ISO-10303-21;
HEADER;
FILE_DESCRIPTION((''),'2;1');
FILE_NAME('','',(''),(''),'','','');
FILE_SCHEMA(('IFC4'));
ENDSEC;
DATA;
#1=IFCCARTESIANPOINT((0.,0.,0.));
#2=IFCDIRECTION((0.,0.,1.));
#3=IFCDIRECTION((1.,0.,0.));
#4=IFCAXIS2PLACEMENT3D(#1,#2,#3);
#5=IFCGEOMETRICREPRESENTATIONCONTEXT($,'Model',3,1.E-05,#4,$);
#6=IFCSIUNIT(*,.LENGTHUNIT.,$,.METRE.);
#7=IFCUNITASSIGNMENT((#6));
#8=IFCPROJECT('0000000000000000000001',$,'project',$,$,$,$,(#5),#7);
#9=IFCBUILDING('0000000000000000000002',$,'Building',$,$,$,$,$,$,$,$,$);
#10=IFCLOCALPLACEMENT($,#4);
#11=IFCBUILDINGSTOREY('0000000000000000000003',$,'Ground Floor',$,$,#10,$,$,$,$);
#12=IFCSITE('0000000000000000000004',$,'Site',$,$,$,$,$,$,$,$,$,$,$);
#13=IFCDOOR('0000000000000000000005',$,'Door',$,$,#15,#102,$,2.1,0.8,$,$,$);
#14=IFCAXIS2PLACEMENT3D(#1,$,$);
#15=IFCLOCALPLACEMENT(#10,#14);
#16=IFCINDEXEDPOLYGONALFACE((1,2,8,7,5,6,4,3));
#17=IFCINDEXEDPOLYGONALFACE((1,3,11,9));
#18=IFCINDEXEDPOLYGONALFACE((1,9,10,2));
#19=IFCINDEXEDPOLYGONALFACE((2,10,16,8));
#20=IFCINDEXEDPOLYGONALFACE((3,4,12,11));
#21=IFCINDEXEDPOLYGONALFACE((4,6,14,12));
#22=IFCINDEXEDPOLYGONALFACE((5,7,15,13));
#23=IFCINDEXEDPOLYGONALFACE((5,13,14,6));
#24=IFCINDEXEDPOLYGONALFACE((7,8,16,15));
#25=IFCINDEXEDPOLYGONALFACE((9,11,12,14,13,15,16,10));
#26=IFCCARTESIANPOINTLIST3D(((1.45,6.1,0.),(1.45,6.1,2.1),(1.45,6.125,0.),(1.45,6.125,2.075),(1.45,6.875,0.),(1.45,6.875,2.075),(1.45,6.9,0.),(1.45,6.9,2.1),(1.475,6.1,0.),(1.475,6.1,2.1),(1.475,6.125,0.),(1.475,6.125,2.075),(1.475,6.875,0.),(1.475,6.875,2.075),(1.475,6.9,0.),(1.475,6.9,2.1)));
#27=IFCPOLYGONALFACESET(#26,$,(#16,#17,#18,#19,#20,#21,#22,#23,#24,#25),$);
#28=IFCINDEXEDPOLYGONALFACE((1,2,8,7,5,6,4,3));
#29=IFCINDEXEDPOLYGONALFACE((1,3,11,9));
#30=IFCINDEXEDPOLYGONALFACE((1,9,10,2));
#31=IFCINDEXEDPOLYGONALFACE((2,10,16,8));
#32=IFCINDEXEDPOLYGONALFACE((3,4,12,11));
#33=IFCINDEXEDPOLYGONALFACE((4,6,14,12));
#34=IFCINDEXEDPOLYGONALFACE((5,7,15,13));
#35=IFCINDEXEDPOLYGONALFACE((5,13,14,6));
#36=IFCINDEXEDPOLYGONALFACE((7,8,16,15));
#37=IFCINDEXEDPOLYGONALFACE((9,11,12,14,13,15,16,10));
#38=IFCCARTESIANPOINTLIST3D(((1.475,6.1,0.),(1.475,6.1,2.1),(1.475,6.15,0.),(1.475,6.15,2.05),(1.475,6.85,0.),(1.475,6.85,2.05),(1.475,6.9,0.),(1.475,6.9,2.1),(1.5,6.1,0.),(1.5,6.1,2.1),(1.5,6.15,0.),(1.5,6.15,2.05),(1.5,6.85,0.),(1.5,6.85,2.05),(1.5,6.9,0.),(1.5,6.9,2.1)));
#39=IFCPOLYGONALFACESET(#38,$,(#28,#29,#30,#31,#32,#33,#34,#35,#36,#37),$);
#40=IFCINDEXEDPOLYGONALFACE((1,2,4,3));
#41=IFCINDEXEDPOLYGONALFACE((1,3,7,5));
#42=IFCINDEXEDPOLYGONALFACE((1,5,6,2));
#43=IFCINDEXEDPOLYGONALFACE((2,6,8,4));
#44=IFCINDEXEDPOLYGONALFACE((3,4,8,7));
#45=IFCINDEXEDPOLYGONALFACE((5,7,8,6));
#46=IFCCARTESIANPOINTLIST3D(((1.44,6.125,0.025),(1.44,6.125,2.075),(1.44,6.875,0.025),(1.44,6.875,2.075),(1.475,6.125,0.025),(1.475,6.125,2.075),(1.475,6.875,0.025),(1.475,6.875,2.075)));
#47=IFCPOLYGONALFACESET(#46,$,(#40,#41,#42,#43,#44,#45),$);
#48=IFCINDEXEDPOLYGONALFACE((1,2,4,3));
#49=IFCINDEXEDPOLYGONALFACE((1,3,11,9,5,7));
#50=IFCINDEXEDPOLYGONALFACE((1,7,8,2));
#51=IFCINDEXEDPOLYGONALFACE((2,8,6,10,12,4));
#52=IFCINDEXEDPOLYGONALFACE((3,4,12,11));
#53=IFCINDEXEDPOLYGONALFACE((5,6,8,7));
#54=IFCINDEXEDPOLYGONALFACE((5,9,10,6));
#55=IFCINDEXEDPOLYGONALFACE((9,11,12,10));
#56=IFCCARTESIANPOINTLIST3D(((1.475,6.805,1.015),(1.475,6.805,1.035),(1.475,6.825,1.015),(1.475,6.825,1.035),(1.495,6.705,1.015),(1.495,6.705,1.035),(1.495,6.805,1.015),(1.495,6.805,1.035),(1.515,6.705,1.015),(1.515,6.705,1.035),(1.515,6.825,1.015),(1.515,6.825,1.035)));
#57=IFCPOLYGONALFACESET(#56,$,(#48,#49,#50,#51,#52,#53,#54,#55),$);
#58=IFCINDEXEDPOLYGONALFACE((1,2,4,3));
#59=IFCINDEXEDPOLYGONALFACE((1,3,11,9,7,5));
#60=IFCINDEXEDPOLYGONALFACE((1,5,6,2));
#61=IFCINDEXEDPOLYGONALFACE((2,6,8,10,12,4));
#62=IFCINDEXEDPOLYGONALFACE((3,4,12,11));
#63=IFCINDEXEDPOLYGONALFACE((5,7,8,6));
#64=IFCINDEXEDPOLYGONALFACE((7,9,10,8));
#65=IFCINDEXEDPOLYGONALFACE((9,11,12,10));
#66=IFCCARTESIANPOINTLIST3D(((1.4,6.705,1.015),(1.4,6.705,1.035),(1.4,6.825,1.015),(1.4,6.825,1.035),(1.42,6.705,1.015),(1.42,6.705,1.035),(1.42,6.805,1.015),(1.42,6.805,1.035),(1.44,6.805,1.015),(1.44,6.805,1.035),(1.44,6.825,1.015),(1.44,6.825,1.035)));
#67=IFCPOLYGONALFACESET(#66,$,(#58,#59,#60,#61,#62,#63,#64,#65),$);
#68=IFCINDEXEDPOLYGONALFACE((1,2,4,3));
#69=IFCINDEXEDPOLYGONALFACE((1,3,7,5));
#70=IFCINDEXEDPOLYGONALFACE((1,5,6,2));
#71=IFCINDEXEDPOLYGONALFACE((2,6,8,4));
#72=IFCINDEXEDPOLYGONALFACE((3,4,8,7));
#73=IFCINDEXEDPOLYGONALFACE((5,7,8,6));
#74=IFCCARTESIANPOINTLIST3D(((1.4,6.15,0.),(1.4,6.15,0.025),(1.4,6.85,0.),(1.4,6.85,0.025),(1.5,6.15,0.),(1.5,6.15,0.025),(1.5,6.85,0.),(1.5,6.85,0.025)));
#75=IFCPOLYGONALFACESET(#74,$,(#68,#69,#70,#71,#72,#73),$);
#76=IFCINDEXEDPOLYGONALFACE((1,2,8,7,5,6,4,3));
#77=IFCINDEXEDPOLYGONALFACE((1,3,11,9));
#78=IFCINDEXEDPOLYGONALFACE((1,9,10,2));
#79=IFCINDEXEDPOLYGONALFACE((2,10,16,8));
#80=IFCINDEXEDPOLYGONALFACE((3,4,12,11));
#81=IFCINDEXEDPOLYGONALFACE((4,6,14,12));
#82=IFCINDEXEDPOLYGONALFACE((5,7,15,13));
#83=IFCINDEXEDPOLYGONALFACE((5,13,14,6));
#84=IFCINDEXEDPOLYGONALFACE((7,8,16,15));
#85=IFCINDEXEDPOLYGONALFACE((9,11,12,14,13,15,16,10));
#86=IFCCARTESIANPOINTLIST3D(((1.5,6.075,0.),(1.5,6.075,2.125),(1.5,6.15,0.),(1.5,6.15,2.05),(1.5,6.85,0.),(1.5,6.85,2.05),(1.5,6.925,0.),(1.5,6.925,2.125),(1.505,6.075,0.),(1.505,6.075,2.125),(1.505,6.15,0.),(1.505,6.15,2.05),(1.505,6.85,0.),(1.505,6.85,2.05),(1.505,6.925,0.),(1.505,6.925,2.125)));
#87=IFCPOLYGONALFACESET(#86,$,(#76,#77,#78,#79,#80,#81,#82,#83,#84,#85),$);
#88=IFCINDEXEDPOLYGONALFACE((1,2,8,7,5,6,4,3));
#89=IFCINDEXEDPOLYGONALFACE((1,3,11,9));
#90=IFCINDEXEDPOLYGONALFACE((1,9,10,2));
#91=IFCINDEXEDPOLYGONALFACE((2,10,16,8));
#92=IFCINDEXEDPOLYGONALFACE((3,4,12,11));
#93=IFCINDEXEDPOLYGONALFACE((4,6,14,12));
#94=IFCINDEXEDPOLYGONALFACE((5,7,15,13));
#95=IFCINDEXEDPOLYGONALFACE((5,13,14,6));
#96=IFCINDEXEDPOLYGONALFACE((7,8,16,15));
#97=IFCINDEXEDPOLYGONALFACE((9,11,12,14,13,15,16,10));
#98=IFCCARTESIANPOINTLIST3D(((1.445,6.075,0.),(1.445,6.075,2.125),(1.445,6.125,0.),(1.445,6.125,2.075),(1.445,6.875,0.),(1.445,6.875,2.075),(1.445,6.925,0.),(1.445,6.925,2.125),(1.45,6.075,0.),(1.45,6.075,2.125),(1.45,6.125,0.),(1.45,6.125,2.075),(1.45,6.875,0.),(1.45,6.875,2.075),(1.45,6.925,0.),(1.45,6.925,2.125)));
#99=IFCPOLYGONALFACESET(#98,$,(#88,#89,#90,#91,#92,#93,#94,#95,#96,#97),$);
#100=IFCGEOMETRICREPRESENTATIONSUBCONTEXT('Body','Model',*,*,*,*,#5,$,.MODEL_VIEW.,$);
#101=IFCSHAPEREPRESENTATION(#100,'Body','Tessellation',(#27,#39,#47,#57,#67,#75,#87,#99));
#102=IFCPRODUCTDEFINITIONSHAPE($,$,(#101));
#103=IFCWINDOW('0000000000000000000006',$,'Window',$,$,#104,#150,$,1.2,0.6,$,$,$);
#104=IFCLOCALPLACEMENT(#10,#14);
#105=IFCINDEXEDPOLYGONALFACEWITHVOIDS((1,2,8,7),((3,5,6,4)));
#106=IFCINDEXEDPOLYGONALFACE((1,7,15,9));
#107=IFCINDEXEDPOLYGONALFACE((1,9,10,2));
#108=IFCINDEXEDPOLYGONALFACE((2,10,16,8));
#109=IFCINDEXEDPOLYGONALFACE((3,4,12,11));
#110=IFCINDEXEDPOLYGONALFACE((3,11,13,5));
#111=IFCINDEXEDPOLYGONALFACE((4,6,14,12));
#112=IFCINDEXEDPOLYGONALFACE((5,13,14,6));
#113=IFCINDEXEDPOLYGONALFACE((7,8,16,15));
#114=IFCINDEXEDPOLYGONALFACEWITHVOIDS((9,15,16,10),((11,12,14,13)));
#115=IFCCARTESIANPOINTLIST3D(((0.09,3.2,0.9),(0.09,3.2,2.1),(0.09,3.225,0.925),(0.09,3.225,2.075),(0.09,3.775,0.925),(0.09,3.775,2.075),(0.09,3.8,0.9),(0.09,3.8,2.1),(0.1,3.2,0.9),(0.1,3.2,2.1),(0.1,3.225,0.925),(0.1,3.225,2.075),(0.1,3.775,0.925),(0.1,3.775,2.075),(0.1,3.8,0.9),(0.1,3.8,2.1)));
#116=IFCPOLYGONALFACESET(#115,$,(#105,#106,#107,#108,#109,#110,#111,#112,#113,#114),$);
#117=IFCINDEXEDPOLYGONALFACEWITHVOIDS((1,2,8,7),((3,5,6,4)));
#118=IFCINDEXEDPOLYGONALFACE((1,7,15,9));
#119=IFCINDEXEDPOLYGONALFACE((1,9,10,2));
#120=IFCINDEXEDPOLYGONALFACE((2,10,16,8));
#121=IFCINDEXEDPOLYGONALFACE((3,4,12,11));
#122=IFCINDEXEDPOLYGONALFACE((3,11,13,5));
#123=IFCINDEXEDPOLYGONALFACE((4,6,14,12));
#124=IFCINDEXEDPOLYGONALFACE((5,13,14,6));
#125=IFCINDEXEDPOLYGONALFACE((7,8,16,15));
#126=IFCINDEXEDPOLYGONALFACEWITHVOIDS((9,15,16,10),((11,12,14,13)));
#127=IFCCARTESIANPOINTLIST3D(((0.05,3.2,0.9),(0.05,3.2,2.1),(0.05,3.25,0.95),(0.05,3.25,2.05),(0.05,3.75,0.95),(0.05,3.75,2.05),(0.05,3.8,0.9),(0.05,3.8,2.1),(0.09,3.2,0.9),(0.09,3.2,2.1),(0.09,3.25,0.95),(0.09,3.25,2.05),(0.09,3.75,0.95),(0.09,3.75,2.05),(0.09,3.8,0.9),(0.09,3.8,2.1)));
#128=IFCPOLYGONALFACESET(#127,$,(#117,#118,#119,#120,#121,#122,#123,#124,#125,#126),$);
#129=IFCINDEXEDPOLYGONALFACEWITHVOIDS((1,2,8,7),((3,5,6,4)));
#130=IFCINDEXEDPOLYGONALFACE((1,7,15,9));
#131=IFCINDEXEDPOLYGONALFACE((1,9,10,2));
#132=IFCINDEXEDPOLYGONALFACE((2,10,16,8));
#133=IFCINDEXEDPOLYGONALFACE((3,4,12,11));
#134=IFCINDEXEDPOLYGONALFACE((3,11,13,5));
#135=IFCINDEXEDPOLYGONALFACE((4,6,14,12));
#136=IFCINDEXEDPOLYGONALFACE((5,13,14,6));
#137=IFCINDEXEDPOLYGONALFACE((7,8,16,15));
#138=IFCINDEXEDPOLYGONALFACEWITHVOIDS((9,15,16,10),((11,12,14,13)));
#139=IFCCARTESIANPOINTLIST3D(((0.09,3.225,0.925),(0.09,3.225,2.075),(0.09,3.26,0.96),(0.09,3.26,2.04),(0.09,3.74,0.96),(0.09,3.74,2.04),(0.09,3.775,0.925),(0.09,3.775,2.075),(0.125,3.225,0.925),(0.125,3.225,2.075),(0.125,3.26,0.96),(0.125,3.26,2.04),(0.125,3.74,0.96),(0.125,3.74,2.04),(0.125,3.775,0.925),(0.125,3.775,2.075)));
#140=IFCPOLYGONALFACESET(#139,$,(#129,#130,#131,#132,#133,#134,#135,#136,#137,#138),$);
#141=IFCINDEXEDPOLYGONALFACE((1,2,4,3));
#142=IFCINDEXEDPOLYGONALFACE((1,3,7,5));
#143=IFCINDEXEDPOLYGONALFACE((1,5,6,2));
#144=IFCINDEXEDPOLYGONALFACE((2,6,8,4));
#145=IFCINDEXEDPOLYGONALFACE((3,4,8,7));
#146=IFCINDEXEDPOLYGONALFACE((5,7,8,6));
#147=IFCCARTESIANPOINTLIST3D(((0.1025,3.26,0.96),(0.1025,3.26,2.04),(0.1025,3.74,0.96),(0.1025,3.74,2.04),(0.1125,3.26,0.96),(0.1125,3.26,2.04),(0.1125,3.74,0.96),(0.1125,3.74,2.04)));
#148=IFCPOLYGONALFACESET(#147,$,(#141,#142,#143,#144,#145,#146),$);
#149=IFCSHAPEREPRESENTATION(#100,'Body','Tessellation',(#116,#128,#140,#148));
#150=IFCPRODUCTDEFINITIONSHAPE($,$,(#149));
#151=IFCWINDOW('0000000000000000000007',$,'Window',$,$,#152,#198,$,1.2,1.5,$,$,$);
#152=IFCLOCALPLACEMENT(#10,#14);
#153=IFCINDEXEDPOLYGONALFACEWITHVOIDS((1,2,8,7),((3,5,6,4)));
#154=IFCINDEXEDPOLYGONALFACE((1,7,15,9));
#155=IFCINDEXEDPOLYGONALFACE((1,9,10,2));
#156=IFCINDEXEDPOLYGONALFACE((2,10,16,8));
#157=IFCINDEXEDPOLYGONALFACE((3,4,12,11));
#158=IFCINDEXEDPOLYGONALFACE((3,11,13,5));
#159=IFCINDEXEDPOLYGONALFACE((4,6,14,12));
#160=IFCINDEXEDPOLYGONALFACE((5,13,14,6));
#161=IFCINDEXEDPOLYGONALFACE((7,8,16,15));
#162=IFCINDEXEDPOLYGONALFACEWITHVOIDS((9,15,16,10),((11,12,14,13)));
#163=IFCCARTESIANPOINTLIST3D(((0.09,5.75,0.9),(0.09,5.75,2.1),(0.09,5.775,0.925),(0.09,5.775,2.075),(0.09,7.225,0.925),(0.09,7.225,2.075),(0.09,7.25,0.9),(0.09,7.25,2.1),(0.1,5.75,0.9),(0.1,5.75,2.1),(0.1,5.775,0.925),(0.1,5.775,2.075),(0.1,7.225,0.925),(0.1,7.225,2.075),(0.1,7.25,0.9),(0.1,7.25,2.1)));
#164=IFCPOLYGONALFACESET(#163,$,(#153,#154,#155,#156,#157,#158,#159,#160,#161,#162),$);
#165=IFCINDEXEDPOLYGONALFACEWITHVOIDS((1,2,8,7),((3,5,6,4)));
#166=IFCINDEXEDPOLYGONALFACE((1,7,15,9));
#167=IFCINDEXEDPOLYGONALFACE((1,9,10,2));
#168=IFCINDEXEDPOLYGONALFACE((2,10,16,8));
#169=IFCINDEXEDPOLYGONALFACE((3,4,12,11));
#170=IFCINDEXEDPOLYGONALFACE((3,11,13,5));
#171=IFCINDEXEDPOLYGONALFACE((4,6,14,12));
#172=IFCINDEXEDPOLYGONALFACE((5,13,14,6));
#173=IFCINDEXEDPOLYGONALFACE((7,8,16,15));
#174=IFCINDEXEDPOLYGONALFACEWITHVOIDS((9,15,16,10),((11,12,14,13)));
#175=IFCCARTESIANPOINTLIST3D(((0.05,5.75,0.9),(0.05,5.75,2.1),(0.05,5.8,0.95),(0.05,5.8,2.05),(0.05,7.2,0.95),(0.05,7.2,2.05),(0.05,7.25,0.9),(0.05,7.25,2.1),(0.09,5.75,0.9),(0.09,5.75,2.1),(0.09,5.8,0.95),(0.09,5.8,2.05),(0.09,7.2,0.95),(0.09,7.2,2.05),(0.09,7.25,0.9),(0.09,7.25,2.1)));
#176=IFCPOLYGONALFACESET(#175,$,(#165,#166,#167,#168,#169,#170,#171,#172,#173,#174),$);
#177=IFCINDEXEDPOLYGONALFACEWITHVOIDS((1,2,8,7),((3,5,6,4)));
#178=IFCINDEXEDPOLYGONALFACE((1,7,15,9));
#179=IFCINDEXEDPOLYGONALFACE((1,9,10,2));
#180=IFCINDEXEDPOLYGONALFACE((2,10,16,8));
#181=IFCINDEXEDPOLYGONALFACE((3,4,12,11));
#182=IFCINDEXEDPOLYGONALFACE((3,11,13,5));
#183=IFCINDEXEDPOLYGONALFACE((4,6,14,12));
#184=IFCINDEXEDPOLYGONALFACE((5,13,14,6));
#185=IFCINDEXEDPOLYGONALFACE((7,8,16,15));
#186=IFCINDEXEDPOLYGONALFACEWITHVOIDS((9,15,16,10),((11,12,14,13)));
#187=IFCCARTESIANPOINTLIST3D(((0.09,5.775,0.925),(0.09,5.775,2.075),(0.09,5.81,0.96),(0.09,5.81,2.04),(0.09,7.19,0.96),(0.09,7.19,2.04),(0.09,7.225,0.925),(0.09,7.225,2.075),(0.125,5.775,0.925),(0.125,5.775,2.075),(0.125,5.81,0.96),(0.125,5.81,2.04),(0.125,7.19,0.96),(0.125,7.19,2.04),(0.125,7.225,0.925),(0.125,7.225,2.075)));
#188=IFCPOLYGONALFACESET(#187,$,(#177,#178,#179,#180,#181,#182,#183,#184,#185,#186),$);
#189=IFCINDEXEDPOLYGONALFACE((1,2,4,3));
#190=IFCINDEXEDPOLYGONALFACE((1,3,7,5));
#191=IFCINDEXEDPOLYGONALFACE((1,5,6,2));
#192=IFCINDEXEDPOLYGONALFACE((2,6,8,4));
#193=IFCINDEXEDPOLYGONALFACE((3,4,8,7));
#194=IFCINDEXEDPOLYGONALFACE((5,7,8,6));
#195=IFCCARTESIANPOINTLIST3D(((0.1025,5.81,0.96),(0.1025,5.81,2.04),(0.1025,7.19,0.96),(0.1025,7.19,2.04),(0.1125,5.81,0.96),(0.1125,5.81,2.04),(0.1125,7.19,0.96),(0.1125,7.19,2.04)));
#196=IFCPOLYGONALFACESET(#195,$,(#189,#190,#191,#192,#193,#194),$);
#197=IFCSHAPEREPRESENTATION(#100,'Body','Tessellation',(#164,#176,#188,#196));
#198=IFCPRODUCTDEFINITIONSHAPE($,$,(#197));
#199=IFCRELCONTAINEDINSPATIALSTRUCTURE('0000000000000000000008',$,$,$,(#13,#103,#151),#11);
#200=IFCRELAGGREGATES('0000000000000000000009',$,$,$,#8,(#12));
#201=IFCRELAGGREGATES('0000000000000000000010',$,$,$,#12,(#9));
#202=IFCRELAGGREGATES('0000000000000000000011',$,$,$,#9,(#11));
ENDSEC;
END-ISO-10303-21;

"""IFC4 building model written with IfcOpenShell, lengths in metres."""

from ifc_helpers import new_model, si_unit, frame, origin_with_axes, place, context, subcontext, project, spatial, line, indexed_curve, outline, extrude, element, save


model = new_model("IFC4")

# Units and contexts
model_context = context("Model", 3, precision=1e-05, world=origin_with_axes())
body_context = subcontext(model_context, "Body", "Model", "MODEL_VIEW")
ifc_project = project(units=[si_unit("LENGTHUNIT", "METRE")], contexts=[model_context])

# Site, building, storey
site = spatial("IfcSite", under=ifc_project, Name="Site")
building = spatial("IfcBuilding", under=site, Name="Building")
storey_placement = place(None, origin_with_axes())
storey = spatial("IfcBuildingStorey", under=building, at=storey_placement, Name="Ground Floor")

# Door
door_1_placement = place(storey_placement, frame((1.5, 6.1, 0.0), z_axis=(0.0, 0.0, 1.0), x_axis=(0.0, 1.0, 0.0)))
element("IfcDoor", 1, at=door_1_placement, inside=storey, Name="Door", OverallHeight=2.1, OverallWidth=0.8, context=body_context, shape_type="SweptSolid", body=[
    extrude(outline(indexed_curve([(0.0, 0.0), (0.0, 2.1), (0.8, 2.1), (0.8, 0.0), (0.775, 0.0), (0.775, 2.075), (0.025, 2.075), (0.025, 0.0)], segments=[line(1, 2, 3, 4, 5, 6, 7, 8, 1)])), frame((0.0, 0.025, 0.0), z_axis=(0.0, -1.0, 0.0), x_axis=(1.0, 0.0, 0.0)), (0.0, 0.0, -1.0), 0.025),
    extrude(outline(indexed_curve([(0.0, 0.0), (0.0, 2.1), (0.8, 2.1), (0.8, 0.0), (0.75, 0.0), (0.75, 2.05), (0.05, 2.05), (0.05, 0.0)], segments=[line(1, 2, 3, 4, 5, 6, 7, 8, 1)])), frame((0.0, 0.0, 0.0), z_axis=(0.0, -1.0, 0.0), x_axis=(1.0, 0.0, 0.0)), (0.0, 0.0, -1.0), 0.025),
    extrude(outline(indexed_curve([(0.0, 0.0), (0.75, 0.0), (0.75, 0.035), (0.0, 0.035)], segments=[line(1, 2, 3, 4, 1)])), frame((0.025, 0.025, 0.025), z_axis=(0.0, 0.0, 1.0), x_axis=(1.0, 0.0, 0.0)), (0.0, 0.0, 1.0), 2.05),
    extrude(outline(indexed_curve([(0.0, 0.0), (0.0, -0.04), (-0.12, -0.04), (-0.12, -0.02), (-0.02, -0.02), (-0.02, 0.0)], segments=[line(1, 2, 3, 4, 5, 6, 1)])), frame((0.725, 0.025, 1.015), z_axis=(0.0, 0.0, 1.0), x_axis=(1.0, 0.0, 0.0)), (0.0, 0.0, 1.0), 0.02),
    extrude(outline(indexed_curve([(0.0, 0.0), (0.0, 0.04), (-0.12, 0.04), (-0.12, 0.02), (-0.02, 0.02), (-0.02, 0.0)], segments=[line(1, 2, 3, 4, 5, 6, 1)])), frame((0.725, 0.06, 1.015), z_axis=(0.0, 0.0, 1.0), x_axis=(1.0, 0.0, 0.0)), (0.0, 0.0, 1.0), 0.02),
    extrude(outline(indexed_curve([(0.0, 0.0), (0.7, 0.0), (0.7, 0.1), (0.0, 0.1)], segments=[line(1, 2, 3, 4, 1)])), frame((0.05, 0.0, 0.0), z_axis=(0.0, 0.0, 1.0), x_axis=(1.0, 0.0, 0.0)), (0.0, 0.0, 1.0), 0.025),
    extrude(outline(indexed_curve([(0.0, 0.0), (0.0, 2.125), (0.85, 2.125), (0.85, 0.0), (0.775, 0.0), (0.775, 2.05), (0.075, 2.05), (0.075, 0.0)], segments=[line(1, 2, 3, 4, 5, 6, 7, 8, 1)])), frame((-0.025, -0.005, 0.0), z_axis=(0.0, -1.0, 0.0), x_axis=(1.0, 0.0, 0.0)), (0.0, 0.0, -1.0), 0.005),
    extrude(outline(indexed_curve([(0.0, 0.0), (0.0, 2.125), (0.85, 2.125), (0.85, 0.0), (0.8, 0.0), (0.8, 2.075), (0.05, 2.075), (0.05, 0.0)], segments=[line(1, 2, 3, 4, 5, 6, 7, 8, 1)])), frame((-0.025, 0.05, 0.0), z_axis=(0.0, -1.0, 0.0), x_axis=(1.0, 0.0, 0.0)), (0.0, 0.0, -1.0), 0.005),
])

# Windows
window_1_placement = place(storey_placement, frame((0.0, 3.8, 0.9), z_axis=(0.0, 0.0, 1.0), x_axis=(0.0, -1.0, 0.0)))
element("IfcWindow", 2, at=window_1_placement, inside=storey, Name="Window", OverallHeight=1.2, OverallWidth=0.6, context=body_context, shape_type="SweptSolid", body=[
    extrude(outline(indexed_curve([(0.0, 0.0), (0.6, 0.0), (0.6, 1.2), (0.0, 1.2)], segments=[line(1, 2, 3, 4, 1)]), holes=[indexed_curve([(0.025, 0.025), (0.575, 0.025), (0.575, 1.175), (0.025, 1.175)], segments=[line(1, 2, 3, 4, 1)])]), frame((0.0, 0.09, 0.0), z_axis=(0.0, -1.0, 0.0), x_axis=(1.0, 0.0, 0.0)), (0.0, 0.0, -1.0), 0.01),
    extrude(outline(indexed_curve([(0.0, 0.0), (0.6, 0.0), (0.6, 1.2), (0.0, 1.2)], segments=[line(1, 2, 3, 4, 1)]), holes=[indexed_curve([(0.05, 0.05), (0.55, 0.05), (0.55, 1.15), (0.05, 1.15)], segments=[line(1, 2, 3, 4, 1)])]), frame((0.0, 0.05, 0.0), z_axis=(0.0, -1.0, 0.0), x_axis=(1.0, 0.0, 0.0)), (0.0, 0.0, -1.0), 0.04),
    extrude(outline(indexed_curve([(0.0, 0.0), (0.55, 0.0), (0.55, 1.15), (0.0, 1.15)], segments=[line(1, 2, 3, 4, 1)]), holes=[indexed_curve([(0.035, 0.035), (0.515, 0.035), (0.515, 1.115), (0.035, 1.115)], segments=[line(1, 2, 3, 4, 1)])]), frame((0.025, 0.09, 0.025), z_axis=(0.0, -1.0, 0.0), x_axis=(1.0, 0.0, 0.0)), (0.0, 0.0, -1.0), 0.035),
    extrude(outline(indexed_curve([(0.035, 0.035), (0.515, 0.035), (0.515, 1.115), (0.035, 1.115)], segments=[line(1, 2, 3, 4, 1)])), frame((0.025, 0.1025, 0.025), z_axis=(0.0, -1.0, 0.0), x_axis=(1.0, 0.0, 0.0)), (0.0, 0.0, -1.0), 0.01),
])
window_2_placement = place(storey_placement, frame((0.0, 7.25, 0.9), z_axis=(0.0, 0.0, 1.0), x_axis=(0.0, -1.0, 0.0)))
element("IfcWindow", 3, at=window_2_placement, inside=storey, Name="Window", OverallHeight=1.2, OverallWidth=1.5, context=body_context, shape_type="SweptSolid", body=[
    extrude(outline(indexed_curve([(0.0, 0.0), (1.5, 0.0), (1.5, 1.2), (0.0, 1.2)], segments=[line(1, 2, 3, 4, 1)]), holes=[indexed_curve([(0.025, 0.025), (1.475, 0.025), (1.475, 1.175), (0.025, 1.175)], segments=[line(1, 2, 3, 4, 1)])]), frame((0.0, 0.09, 0.0), z_axis=(0.0, -1.0, 0.0), x_axis=(1.0, 0.0, 0.0)), (0.0, 0.0, -1.0), 0.01),
    extrude(outline(indexed_curve([(0.0, 0.0), (1.5, 0.0), (1.5, 1.2), (0.0, 1.2)], segments=[line(1, 2, 3, 4, 1)]), holes=[indexed_curve([(0.05, 0.05), (1.45, 0.05), (1.45, 1.15), (0.05, 1.15)], segments=[line(1, 2, 3, 4, 1)])]), frame((0.0, 0.05, 0.0), z_axis=(0.0, -1.0, 0.0), x_axis=(1.0, 0.0, 0.0)), (0.0, 0.0, -1.0), 0.04),
    extrude(outline(indexed_curve([(0.0, 0.0), (1.45, 0.0), (1.45, 1.15), (0.0, 1.15)], segments=[line(1, 2, 3, 4, 1)]), holes=[indexed_curve([(0.035, 0.035), (1.415, 0.035), (1.415, 1.115), (0.035, 1.115)], segments=[line(1, 2, 3, 4, 1)])]), frame((0.025, 0.09, 0.025), z_axis=(0.0, -1.0, 0.0), x_axis=(1.0, 0.0, 0.0)), (0.0, 0.0, -1.0), 0.035),
    extrude(outline(indexed_curve([(0.035, 0.035), (1.415, 0.035), (1.415, 1.115), (0.035, 1.115)], segments=[line(1, 2, 3, 4, 1)])), frame((0.025, 0.1025, 0.025), z_axis=(0.0, -1.0, 0.0), x_axis=(1.0, 0.0, 0.0)), (0.0, 0.0, -1.0), 0.01),
])

save(model, "model.ifc")
